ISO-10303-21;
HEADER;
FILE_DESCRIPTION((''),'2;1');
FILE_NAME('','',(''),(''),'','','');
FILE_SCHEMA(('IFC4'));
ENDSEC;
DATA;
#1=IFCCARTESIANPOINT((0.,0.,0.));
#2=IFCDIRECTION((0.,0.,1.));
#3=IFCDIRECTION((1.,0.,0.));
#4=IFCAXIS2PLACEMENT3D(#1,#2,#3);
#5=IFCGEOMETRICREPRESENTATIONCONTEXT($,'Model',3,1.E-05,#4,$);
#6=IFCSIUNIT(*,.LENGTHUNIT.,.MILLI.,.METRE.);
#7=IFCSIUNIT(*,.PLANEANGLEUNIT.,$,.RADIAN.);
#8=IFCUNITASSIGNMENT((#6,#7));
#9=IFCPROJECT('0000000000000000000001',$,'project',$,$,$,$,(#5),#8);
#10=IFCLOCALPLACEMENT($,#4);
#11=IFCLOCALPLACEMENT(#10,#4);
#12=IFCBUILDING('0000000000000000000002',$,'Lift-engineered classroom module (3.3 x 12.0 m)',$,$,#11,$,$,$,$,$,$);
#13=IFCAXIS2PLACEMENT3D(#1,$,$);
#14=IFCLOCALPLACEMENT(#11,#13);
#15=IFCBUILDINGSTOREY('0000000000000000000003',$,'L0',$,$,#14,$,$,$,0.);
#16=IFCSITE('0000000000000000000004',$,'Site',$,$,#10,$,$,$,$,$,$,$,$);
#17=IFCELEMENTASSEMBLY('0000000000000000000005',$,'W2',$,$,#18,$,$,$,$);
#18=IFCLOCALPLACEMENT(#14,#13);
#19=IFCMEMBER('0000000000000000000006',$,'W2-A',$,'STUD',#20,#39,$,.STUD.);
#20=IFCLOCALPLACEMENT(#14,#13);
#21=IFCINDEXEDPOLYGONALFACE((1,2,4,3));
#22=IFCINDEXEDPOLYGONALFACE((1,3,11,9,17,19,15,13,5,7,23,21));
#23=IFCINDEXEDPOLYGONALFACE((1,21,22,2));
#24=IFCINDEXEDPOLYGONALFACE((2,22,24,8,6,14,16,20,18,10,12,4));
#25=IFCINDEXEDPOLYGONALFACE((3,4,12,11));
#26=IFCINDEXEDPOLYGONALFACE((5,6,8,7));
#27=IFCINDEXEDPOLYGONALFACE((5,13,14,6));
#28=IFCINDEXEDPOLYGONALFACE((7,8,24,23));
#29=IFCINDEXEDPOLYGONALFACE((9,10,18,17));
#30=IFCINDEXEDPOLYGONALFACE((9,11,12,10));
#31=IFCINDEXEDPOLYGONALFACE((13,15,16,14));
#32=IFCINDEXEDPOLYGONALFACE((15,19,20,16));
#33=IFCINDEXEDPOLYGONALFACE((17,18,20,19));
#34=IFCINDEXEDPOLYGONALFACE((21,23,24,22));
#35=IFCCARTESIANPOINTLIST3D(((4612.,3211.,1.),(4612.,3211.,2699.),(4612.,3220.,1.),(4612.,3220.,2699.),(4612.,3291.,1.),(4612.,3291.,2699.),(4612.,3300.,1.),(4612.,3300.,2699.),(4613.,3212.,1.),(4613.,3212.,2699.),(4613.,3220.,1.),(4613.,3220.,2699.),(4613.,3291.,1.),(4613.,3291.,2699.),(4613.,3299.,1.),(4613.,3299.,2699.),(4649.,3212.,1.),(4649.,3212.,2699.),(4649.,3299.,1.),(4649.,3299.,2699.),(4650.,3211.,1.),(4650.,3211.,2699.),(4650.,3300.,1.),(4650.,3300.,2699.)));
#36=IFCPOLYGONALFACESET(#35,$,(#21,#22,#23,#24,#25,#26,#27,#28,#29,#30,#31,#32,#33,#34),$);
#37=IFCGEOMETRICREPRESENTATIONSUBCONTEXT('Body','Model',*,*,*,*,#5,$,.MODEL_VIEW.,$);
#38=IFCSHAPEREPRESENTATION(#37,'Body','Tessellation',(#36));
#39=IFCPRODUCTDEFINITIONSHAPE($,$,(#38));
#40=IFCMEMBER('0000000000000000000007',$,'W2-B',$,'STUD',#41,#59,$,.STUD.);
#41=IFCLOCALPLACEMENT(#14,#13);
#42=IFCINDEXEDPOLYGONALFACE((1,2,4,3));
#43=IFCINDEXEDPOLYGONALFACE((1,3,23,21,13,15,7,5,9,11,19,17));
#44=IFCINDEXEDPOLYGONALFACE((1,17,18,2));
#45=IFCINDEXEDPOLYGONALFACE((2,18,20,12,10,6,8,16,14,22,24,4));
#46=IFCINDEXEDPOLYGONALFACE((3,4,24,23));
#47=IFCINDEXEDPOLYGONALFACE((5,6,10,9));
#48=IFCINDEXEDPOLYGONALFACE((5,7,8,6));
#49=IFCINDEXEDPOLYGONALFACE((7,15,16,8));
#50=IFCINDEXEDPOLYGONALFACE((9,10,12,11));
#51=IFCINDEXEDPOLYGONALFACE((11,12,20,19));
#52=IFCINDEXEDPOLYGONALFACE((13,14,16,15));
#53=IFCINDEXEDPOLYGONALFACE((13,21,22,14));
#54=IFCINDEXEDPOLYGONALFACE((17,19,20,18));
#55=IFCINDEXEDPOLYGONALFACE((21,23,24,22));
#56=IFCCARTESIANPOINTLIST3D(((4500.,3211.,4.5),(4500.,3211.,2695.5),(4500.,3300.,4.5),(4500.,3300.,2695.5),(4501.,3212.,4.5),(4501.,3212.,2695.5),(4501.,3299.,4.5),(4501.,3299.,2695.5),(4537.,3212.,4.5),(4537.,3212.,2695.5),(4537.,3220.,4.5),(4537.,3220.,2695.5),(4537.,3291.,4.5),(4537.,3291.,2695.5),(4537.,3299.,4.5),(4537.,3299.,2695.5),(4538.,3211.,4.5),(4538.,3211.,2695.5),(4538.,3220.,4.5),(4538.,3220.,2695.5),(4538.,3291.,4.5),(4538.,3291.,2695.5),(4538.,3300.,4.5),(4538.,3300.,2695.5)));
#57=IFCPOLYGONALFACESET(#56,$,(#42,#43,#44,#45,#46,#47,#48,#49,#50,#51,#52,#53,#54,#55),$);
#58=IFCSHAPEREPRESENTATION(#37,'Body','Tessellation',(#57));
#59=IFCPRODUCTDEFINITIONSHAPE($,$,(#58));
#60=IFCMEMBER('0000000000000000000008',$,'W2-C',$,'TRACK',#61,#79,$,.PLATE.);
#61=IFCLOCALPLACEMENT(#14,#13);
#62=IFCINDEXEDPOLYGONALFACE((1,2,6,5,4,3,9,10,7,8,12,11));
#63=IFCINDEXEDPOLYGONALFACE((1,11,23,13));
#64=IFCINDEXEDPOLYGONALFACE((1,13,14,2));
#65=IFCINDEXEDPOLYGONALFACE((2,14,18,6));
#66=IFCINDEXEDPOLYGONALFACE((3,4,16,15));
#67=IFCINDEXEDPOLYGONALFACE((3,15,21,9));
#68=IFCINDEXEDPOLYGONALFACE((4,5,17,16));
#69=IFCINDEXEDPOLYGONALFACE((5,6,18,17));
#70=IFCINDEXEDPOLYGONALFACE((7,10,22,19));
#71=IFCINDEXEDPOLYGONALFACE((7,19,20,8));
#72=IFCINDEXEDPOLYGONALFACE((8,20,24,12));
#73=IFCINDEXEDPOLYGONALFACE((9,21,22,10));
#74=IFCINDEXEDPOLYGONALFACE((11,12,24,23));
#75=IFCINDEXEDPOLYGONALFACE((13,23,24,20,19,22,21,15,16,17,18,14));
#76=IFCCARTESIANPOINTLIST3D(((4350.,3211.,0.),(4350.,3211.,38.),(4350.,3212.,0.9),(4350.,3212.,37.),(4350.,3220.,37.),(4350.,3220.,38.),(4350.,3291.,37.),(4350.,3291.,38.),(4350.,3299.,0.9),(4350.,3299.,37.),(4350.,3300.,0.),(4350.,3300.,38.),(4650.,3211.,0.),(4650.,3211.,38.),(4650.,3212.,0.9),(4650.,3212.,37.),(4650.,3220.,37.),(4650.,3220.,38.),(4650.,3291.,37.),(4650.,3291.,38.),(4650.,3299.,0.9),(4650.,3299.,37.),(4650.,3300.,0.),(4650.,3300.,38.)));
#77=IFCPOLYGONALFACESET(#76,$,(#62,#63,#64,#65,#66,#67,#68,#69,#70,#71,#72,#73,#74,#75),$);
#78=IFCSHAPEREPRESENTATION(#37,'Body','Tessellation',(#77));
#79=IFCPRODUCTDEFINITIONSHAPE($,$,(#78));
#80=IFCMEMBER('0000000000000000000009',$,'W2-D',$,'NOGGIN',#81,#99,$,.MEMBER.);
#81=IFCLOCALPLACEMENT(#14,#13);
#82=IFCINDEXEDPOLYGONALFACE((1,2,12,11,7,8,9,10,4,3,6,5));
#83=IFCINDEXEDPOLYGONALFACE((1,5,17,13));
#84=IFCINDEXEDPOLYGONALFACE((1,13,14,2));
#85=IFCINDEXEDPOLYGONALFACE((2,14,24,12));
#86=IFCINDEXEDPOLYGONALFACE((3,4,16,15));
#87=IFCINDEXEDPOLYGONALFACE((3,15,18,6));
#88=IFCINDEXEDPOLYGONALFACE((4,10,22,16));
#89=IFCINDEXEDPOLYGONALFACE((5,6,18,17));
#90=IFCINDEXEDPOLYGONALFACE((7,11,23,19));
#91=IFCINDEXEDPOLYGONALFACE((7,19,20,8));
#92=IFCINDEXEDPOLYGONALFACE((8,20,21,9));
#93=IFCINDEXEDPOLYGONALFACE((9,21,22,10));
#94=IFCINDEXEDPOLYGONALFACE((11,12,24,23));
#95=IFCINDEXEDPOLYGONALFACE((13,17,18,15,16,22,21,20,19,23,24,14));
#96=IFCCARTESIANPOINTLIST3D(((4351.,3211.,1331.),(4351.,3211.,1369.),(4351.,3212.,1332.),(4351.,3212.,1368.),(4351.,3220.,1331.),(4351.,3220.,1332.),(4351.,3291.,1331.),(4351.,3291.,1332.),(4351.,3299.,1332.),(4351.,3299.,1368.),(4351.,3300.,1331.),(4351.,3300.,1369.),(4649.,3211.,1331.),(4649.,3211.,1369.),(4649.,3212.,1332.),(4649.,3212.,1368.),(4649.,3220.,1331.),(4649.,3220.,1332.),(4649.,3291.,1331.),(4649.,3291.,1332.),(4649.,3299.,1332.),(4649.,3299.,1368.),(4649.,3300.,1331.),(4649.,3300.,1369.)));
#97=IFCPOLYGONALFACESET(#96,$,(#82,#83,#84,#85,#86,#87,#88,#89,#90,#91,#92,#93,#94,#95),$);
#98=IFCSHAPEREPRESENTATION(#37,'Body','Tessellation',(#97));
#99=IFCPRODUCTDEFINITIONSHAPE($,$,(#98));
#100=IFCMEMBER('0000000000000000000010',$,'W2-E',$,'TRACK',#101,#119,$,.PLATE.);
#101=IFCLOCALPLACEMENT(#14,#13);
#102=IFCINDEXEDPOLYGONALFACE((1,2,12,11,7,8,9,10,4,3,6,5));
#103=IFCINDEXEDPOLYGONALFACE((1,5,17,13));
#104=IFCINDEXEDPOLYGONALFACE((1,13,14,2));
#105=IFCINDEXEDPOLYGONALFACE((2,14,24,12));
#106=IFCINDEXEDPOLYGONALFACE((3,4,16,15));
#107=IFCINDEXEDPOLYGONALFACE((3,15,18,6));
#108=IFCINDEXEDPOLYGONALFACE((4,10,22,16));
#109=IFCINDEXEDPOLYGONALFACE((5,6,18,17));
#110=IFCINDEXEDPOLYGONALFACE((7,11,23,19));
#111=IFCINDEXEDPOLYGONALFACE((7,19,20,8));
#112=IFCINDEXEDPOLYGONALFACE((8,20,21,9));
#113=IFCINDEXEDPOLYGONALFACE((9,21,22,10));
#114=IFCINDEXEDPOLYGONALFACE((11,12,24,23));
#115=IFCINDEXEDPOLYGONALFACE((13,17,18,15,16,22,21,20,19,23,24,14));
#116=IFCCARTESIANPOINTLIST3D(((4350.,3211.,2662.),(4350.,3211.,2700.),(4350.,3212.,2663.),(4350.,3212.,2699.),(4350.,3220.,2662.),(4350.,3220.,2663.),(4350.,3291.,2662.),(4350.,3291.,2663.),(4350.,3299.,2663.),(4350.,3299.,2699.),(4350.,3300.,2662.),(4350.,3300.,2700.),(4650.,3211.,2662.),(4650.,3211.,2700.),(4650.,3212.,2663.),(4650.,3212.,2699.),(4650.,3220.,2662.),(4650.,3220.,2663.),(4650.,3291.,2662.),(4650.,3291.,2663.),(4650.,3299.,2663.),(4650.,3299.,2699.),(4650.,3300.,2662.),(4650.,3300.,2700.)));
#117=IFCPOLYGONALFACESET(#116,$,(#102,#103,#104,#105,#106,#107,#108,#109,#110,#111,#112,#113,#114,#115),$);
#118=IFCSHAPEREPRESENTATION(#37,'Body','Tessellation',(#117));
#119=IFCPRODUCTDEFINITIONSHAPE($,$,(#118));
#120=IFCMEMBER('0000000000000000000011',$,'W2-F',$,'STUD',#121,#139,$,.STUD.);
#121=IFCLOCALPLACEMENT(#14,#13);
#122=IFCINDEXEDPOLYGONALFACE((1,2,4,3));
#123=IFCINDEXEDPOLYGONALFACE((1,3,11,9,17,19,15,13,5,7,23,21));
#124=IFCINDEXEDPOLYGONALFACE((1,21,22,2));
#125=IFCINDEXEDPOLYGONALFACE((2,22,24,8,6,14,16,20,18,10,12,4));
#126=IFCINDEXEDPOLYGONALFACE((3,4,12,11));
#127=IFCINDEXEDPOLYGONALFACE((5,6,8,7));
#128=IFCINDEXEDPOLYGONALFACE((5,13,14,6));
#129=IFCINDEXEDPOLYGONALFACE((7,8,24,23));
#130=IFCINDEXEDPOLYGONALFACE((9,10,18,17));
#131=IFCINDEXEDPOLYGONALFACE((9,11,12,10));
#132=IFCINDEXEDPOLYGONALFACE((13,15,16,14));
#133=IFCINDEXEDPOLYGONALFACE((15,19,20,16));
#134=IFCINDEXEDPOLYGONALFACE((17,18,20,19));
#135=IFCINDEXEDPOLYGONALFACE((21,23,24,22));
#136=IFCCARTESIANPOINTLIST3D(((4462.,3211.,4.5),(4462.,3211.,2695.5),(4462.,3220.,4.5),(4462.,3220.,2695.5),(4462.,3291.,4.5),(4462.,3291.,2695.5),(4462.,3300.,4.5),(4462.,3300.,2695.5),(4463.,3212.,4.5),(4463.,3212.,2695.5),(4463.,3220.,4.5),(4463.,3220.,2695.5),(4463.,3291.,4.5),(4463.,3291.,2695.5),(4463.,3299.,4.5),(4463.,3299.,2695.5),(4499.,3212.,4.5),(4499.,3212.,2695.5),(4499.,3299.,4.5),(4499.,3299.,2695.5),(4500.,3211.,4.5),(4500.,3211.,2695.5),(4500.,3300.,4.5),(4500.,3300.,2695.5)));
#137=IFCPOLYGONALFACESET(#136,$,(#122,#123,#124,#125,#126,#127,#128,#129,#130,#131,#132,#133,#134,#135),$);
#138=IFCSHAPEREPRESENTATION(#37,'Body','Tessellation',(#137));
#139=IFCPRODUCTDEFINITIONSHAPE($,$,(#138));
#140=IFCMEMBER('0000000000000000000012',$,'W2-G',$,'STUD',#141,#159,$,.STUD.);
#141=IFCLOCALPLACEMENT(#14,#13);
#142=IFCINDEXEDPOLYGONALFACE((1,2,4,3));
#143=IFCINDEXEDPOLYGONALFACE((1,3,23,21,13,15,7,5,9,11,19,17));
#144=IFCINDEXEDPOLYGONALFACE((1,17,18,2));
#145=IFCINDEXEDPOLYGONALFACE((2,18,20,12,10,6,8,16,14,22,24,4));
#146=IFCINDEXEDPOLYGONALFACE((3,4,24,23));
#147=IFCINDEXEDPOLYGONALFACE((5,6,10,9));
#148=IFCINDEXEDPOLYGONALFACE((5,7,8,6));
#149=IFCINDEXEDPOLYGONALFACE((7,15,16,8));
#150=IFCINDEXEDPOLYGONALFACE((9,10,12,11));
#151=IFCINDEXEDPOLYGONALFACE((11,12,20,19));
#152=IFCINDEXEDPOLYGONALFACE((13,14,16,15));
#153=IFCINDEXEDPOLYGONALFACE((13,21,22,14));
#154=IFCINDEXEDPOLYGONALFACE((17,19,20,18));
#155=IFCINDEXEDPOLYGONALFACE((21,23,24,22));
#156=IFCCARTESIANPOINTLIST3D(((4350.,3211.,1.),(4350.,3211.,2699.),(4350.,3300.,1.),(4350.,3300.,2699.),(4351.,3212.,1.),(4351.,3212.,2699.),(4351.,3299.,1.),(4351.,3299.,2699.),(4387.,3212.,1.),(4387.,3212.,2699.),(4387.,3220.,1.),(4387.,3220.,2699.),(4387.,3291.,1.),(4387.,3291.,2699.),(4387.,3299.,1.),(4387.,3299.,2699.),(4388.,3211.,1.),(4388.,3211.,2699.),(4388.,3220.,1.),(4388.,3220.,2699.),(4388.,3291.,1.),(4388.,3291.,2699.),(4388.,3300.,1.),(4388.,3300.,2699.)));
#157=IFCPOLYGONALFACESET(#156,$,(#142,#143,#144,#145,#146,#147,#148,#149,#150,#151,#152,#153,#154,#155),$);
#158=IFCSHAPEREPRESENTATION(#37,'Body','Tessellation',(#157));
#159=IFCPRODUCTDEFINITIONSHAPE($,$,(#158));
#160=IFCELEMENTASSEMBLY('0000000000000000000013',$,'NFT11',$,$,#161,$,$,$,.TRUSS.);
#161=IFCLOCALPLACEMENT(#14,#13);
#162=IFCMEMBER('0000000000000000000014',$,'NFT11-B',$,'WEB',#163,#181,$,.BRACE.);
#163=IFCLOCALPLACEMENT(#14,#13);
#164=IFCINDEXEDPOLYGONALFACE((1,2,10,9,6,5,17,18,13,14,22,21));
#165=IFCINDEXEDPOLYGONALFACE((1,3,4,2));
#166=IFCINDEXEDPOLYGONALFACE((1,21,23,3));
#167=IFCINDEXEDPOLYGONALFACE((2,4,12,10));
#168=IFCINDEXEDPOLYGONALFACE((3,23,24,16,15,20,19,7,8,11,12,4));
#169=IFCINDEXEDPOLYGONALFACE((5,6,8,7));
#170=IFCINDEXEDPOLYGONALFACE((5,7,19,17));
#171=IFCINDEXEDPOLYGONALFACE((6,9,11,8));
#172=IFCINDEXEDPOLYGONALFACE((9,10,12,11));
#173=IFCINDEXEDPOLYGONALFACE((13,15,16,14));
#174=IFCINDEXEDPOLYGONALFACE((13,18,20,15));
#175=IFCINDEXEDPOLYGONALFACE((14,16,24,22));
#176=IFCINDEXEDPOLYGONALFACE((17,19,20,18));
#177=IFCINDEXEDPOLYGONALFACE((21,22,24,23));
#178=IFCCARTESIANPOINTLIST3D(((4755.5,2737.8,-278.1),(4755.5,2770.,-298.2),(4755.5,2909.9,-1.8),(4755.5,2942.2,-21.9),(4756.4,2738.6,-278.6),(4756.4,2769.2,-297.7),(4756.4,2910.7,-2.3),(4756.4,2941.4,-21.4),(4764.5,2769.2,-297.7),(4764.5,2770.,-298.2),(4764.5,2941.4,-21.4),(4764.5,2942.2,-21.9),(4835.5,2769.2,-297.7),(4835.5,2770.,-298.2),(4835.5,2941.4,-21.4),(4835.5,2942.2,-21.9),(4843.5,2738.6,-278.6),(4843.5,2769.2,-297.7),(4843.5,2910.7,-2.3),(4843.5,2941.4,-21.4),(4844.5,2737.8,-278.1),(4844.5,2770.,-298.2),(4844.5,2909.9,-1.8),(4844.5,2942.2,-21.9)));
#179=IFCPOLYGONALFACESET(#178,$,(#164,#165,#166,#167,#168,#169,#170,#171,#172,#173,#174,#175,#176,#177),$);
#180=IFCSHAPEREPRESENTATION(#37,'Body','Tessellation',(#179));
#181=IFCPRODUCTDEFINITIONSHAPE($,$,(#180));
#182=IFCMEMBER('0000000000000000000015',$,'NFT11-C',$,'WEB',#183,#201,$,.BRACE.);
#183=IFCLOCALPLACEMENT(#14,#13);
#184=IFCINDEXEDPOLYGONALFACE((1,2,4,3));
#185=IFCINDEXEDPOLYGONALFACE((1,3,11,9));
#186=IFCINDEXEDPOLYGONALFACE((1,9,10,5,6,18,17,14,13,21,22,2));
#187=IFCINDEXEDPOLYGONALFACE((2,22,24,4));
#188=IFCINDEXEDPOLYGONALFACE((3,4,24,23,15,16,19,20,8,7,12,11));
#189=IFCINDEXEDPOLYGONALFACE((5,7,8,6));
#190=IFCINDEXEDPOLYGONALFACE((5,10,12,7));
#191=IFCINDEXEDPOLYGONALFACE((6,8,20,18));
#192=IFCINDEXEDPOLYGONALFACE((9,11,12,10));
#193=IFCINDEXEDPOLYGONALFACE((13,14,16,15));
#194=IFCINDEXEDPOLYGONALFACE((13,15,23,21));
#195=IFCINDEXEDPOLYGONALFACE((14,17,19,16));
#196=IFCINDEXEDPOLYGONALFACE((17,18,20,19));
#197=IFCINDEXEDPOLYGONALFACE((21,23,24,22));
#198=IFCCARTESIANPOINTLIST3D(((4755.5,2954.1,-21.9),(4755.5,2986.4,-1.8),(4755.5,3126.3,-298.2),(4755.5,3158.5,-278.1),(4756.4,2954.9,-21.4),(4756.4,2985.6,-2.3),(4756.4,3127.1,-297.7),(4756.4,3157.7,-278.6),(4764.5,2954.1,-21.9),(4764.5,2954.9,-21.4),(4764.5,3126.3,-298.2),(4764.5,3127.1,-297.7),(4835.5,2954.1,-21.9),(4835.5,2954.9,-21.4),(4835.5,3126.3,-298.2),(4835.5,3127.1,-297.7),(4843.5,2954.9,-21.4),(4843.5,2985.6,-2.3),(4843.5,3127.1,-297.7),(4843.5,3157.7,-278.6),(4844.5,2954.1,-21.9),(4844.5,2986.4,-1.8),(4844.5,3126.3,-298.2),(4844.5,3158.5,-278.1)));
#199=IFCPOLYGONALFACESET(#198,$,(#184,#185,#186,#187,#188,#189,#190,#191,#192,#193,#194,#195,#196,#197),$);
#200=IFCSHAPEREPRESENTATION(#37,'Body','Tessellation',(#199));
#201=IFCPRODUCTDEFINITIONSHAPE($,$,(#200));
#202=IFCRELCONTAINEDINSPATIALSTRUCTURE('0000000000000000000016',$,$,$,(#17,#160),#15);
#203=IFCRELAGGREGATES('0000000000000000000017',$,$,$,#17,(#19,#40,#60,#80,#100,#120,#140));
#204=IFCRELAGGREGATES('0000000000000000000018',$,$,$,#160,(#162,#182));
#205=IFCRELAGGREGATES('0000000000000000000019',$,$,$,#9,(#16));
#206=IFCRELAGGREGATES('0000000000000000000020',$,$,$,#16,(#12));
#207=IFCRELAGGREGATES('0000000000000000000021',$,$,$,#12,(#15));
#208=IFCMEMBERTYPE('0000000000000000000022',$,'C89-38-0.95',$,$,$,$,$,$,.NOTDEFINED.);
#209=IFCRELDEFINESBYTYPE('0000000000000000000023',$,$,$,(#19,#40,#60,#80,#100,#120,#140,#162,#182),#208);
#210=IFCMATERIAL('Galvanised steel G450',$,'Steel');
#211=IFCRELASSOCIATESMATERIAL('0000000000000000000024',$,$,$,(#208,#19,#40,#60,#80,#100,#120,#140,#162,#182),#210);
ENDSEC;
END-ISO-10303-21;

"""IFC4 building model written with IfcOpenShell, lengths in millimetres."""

from ifc_helpers import new_model, si_unit, frame, origin, origin_with_axes, origin_2d, place, context, subcontext, project, spatial, c_section, extrude, material, material_profile, profile_set, profile_usage, type_object, element, aggregate, save


model = new_model("IFC4")

# Units and contexts
model_context = context("Model", 3, precision=1e-05, world=origin_with_axes())
body_context = subcontext(model_context, "Body", "Model", "MODEL_VIEW")
ifc_project = project(units=[si_unit("LENGTHUNIT", "METRE", prefix="MILLI"), si_unit("PLANEANGLEUNIT", "RADIAN")], contexts=[model_context])

# Site, building, storey
site_placement = place(None, origin_with_axes())
site = spatial("IfcSite", under=ifc_project, at=site_placement, Name="Site")
building_placement = place(site_placement, origin_with_axes())
building = spatial("IfcBuilding", under=site, at=building_placement, Name="Lift-engineered classroom module (3.3 x 12.0 m)")
storey_placement = place(building_placement, origin())
storey = spatial("IfcBuildingStorey", under=building, at=storey_placement, Name="L0", Elevation=0.0)

# Element assemblies, members
assembly_1_placement = place(storey_placement, frame((4650.0, 3255.5, 0.0)))
assembly_1 = element("IfcElementAssembly", 1, at=assembly_1_placement, inside=storey, Name="W2")
ifc_material = material(Name="Galvanised steel G450", Category="Steel")
ifc_material_profile_1 = material_profile(ifc_material, c_section(Depth=89.0, Width=38.0, WallThickness=0.9, Girth=9.0, at=origin_2d()), Name="C89-38-0.95")
ifc_profile_set_1 = profile_set([ifc_material_profile_1], Name="C89-38-0.95")
ifc_profile_usage_1 = profile_usage(ifc_profile_set_1)
member_type_1 = type_object("IfcMemberType", Name="C89-38-0.95", PredefinedType="NOTDEFINED", material=ifc_profile_set_1)
member_1_placement = place(assembly_1_placement, frame((-19.0, 0.0, 2699.1), z_axis=(0.0, 0.0, -1.0), x_axis=(-1.0, 0.0, 0.0)))
member_1 = element("IfcMember", 2, at=member_1_placement, type_object=member_type_1, material=ifc_profile_usage_1, Name="W2-A", ObjectType="STUD", PredefinedType="STUD", context=body_context, shape_type="SweptSolid", body=[
    extrude(c_section(Depth=89.0, Width=38.0, WallThickness=0.9, Girth=9.0, at=origin_2d()), origin(), (0.0, 0.0, 1.0), 2698.1),
])
member_2_placement = place(assembly_1_placement, frame((-131.0, 0.0, 4.5), z_axis=(0.0, 0.0, 1.0), x_axis=(1.0, 0.0, 0.0)))
member_2 = element("IfcMember", 3, at=member_2_placement, type_object=member_type_1, material=ifc_profile_usage_1, Name="W2-B", ObjectType="STUD", PredefinedType="STUD", context=body_context, shape_type="SweptSolid", body=[
    extrude(c_section(Depth=89.0, Width=38.0, WallThickness=0.9, Girth=9.0, at=origin_2d()), origin(), (0.0, 0.0, 1.0), 2691.0),
])
member_3_placement = place(assembly_1_placement, frame((0.0, 0.0, 19.0), z_axis=(-1.0, 0.0, 0.0), x_axis=(0.0, 0.0, 1.0)))
member_3 = element("IfcMember", 4, at=member_3_placement, type_object=member_type_1, material=ifc_profile_usage_1, Name="W2-C", ObjectType="TRACK", PredefinedType="PLATE", context=body_context, shape_type="SweptSolid", body=[
    extrude(c_section(Depth=89.0, Width=38.0, WallThickness=0.9, Girth=9.0, at=origin_2d()), origin(), (0.0, 0.0, 1.0), 300.0),
])
member_4_placement = place(assembly_1_placement, frame((-299.1, 0.0, 1350.0), z_axis=(1.0, 0.0, 0.0), x_axis=(0.0, 0.0, -1.0)))
member_4 = element("IfcMember", 5, at=member_4_placement, type_object=member_type_1, material=ifc_profile_usage_1, Name="W2-D", ObjectType="NOGGIN", PredefinedType="MEMBER", context=body_context, shape_type="SweptSolid", body=[
    extrude(c_section(Depth=89.0, Width=38.0, WallThickness=0.9, Girth=9.0, at=origin_2d()), origin(), (0.0, 0.0, 1.0), 298.1),
])
member_5_placement = place(assembly_1_placement, frame((-300.0, 0.0, 2681.0), z_axis=(1.0, 0.0, 0.0), x_axis=(0.0, 0.0, -1.0)))
member_5 = element("IfcMember", 6, at=member_5_placement, type_object=member_type_1, material=ifc_profile_usage_1, Name="W2-E", ObjectType="TRACK", PredefinedType="PLATE", context=body_context, shape_type="SweptSolid", body=[
    extrude(c_section(Depth=89.0, Width=38.0, WallThickness=0.9, Girth=9.0, at=origin_2d()), origin(), (0.0, 0.0, 1.0), 300.0),
])
member_6_placement = place(assembly_1_placement, frame((-169.0, 0.0, 2695.5), z_axis=(0.0, 0.0, -1.0), x_axis=(-1.0, 0.0, 0.0)))
member_6 = element("IfcMember", 7, at=member_6_placement, type_object=member_type_1, material=ifc_profile_usage_1, Name="W2-F", ObjectType="STUD", PredefinedType="STUD", context=body_context, shape_type="SweptSolid", body=[
    extrude(c_section(Depth=89.0, Width=38.0, WallThickness=0.9, Girth=9.0, at=origin_2d()), origin(), (0.0, 0.0, 1.0), 2691.0),
])
member_7_placement = place(assembly_1_placement, frame((-281.0, 0.0, 0.9), z_axis=(0.0, 0.0, 1.0), x_axis=(1.0, 0.0, 0.0)))
member_7 = element("IfcMember", 8, at=member_7_placement, type_object=member_type_1, material=ifc_profile_usage_1, Name="W2-G", ObjectType="STUD", PredefinedType="STUD", context=body_context, shape_type="SweptSolid", body=[
    extrude(c_section(Depth=89.0, Width=38.0, WallThickness=0.9, Girth=9.0, at=origin_2d()), origin(), (0.0, 0.0, 1.0), 2698.1),
])
aggregate(assembly_1, [member_1, member_2, member_3, member_4, member_5, member_6, member_7])
assembly_2_placement = place(storey_placement, frame((4800.0, 89.0, -300.0)))
assembly_2 = element("IfcElementAssembly", 9, at=assembly_2_placement, inside=storey, Name="NFT11", PredefinedType="TRUSS")
member_8_placement = place(assembly_2_placement, frame((0.0, 2664.9, 11.8), z_axis=(0.0, 0.528797, 0.848748), x_axis=(0.0, 0.848748, -0.528797)))
member_8 = element("IfcMember", 10, at=member_8_placement, type_object=member_type_1, material=ifc_profile_usage_1, Name="NFT11-B", ObjectType="WEB", PredefinedType="BRACE", context=body_context, shape_type="SweptSolid", body=[
    extrude(c_section(Depth=89.0, Width=38.0, WallThickness=0.9, Girth=9.0, at=origin_2d()), origin(), (0.0, 0.0, 1.0), 325.6),
])
member_9_placement = place(assembly_2_placement, frame((0.0, 3053.4, 11.8), z_axis=(0.0, -0.528797, 0.848748), x_axis=(0.0, -0.848748, -0.528797)))
member_9 = element("IfcMember", 11, at=member_9_placement, type_object=member_type_1, material=ifc_profile_usage_1, Name="NFT11-C", ObjectType="WEB", PredefinedType="BRACE", context=body_context, shape_type="SweptSolid", body=[
    extrude(c_section(Depth=89.0, Width=38.0, WallThickness=0.9, Girth=9.0, at=origin_2d()), origin(), (0.0, 0.0, 1.0), 325.6),
])
aggregate(assembly_2, [member_8, member_9])

save(model, "model.ifc")
